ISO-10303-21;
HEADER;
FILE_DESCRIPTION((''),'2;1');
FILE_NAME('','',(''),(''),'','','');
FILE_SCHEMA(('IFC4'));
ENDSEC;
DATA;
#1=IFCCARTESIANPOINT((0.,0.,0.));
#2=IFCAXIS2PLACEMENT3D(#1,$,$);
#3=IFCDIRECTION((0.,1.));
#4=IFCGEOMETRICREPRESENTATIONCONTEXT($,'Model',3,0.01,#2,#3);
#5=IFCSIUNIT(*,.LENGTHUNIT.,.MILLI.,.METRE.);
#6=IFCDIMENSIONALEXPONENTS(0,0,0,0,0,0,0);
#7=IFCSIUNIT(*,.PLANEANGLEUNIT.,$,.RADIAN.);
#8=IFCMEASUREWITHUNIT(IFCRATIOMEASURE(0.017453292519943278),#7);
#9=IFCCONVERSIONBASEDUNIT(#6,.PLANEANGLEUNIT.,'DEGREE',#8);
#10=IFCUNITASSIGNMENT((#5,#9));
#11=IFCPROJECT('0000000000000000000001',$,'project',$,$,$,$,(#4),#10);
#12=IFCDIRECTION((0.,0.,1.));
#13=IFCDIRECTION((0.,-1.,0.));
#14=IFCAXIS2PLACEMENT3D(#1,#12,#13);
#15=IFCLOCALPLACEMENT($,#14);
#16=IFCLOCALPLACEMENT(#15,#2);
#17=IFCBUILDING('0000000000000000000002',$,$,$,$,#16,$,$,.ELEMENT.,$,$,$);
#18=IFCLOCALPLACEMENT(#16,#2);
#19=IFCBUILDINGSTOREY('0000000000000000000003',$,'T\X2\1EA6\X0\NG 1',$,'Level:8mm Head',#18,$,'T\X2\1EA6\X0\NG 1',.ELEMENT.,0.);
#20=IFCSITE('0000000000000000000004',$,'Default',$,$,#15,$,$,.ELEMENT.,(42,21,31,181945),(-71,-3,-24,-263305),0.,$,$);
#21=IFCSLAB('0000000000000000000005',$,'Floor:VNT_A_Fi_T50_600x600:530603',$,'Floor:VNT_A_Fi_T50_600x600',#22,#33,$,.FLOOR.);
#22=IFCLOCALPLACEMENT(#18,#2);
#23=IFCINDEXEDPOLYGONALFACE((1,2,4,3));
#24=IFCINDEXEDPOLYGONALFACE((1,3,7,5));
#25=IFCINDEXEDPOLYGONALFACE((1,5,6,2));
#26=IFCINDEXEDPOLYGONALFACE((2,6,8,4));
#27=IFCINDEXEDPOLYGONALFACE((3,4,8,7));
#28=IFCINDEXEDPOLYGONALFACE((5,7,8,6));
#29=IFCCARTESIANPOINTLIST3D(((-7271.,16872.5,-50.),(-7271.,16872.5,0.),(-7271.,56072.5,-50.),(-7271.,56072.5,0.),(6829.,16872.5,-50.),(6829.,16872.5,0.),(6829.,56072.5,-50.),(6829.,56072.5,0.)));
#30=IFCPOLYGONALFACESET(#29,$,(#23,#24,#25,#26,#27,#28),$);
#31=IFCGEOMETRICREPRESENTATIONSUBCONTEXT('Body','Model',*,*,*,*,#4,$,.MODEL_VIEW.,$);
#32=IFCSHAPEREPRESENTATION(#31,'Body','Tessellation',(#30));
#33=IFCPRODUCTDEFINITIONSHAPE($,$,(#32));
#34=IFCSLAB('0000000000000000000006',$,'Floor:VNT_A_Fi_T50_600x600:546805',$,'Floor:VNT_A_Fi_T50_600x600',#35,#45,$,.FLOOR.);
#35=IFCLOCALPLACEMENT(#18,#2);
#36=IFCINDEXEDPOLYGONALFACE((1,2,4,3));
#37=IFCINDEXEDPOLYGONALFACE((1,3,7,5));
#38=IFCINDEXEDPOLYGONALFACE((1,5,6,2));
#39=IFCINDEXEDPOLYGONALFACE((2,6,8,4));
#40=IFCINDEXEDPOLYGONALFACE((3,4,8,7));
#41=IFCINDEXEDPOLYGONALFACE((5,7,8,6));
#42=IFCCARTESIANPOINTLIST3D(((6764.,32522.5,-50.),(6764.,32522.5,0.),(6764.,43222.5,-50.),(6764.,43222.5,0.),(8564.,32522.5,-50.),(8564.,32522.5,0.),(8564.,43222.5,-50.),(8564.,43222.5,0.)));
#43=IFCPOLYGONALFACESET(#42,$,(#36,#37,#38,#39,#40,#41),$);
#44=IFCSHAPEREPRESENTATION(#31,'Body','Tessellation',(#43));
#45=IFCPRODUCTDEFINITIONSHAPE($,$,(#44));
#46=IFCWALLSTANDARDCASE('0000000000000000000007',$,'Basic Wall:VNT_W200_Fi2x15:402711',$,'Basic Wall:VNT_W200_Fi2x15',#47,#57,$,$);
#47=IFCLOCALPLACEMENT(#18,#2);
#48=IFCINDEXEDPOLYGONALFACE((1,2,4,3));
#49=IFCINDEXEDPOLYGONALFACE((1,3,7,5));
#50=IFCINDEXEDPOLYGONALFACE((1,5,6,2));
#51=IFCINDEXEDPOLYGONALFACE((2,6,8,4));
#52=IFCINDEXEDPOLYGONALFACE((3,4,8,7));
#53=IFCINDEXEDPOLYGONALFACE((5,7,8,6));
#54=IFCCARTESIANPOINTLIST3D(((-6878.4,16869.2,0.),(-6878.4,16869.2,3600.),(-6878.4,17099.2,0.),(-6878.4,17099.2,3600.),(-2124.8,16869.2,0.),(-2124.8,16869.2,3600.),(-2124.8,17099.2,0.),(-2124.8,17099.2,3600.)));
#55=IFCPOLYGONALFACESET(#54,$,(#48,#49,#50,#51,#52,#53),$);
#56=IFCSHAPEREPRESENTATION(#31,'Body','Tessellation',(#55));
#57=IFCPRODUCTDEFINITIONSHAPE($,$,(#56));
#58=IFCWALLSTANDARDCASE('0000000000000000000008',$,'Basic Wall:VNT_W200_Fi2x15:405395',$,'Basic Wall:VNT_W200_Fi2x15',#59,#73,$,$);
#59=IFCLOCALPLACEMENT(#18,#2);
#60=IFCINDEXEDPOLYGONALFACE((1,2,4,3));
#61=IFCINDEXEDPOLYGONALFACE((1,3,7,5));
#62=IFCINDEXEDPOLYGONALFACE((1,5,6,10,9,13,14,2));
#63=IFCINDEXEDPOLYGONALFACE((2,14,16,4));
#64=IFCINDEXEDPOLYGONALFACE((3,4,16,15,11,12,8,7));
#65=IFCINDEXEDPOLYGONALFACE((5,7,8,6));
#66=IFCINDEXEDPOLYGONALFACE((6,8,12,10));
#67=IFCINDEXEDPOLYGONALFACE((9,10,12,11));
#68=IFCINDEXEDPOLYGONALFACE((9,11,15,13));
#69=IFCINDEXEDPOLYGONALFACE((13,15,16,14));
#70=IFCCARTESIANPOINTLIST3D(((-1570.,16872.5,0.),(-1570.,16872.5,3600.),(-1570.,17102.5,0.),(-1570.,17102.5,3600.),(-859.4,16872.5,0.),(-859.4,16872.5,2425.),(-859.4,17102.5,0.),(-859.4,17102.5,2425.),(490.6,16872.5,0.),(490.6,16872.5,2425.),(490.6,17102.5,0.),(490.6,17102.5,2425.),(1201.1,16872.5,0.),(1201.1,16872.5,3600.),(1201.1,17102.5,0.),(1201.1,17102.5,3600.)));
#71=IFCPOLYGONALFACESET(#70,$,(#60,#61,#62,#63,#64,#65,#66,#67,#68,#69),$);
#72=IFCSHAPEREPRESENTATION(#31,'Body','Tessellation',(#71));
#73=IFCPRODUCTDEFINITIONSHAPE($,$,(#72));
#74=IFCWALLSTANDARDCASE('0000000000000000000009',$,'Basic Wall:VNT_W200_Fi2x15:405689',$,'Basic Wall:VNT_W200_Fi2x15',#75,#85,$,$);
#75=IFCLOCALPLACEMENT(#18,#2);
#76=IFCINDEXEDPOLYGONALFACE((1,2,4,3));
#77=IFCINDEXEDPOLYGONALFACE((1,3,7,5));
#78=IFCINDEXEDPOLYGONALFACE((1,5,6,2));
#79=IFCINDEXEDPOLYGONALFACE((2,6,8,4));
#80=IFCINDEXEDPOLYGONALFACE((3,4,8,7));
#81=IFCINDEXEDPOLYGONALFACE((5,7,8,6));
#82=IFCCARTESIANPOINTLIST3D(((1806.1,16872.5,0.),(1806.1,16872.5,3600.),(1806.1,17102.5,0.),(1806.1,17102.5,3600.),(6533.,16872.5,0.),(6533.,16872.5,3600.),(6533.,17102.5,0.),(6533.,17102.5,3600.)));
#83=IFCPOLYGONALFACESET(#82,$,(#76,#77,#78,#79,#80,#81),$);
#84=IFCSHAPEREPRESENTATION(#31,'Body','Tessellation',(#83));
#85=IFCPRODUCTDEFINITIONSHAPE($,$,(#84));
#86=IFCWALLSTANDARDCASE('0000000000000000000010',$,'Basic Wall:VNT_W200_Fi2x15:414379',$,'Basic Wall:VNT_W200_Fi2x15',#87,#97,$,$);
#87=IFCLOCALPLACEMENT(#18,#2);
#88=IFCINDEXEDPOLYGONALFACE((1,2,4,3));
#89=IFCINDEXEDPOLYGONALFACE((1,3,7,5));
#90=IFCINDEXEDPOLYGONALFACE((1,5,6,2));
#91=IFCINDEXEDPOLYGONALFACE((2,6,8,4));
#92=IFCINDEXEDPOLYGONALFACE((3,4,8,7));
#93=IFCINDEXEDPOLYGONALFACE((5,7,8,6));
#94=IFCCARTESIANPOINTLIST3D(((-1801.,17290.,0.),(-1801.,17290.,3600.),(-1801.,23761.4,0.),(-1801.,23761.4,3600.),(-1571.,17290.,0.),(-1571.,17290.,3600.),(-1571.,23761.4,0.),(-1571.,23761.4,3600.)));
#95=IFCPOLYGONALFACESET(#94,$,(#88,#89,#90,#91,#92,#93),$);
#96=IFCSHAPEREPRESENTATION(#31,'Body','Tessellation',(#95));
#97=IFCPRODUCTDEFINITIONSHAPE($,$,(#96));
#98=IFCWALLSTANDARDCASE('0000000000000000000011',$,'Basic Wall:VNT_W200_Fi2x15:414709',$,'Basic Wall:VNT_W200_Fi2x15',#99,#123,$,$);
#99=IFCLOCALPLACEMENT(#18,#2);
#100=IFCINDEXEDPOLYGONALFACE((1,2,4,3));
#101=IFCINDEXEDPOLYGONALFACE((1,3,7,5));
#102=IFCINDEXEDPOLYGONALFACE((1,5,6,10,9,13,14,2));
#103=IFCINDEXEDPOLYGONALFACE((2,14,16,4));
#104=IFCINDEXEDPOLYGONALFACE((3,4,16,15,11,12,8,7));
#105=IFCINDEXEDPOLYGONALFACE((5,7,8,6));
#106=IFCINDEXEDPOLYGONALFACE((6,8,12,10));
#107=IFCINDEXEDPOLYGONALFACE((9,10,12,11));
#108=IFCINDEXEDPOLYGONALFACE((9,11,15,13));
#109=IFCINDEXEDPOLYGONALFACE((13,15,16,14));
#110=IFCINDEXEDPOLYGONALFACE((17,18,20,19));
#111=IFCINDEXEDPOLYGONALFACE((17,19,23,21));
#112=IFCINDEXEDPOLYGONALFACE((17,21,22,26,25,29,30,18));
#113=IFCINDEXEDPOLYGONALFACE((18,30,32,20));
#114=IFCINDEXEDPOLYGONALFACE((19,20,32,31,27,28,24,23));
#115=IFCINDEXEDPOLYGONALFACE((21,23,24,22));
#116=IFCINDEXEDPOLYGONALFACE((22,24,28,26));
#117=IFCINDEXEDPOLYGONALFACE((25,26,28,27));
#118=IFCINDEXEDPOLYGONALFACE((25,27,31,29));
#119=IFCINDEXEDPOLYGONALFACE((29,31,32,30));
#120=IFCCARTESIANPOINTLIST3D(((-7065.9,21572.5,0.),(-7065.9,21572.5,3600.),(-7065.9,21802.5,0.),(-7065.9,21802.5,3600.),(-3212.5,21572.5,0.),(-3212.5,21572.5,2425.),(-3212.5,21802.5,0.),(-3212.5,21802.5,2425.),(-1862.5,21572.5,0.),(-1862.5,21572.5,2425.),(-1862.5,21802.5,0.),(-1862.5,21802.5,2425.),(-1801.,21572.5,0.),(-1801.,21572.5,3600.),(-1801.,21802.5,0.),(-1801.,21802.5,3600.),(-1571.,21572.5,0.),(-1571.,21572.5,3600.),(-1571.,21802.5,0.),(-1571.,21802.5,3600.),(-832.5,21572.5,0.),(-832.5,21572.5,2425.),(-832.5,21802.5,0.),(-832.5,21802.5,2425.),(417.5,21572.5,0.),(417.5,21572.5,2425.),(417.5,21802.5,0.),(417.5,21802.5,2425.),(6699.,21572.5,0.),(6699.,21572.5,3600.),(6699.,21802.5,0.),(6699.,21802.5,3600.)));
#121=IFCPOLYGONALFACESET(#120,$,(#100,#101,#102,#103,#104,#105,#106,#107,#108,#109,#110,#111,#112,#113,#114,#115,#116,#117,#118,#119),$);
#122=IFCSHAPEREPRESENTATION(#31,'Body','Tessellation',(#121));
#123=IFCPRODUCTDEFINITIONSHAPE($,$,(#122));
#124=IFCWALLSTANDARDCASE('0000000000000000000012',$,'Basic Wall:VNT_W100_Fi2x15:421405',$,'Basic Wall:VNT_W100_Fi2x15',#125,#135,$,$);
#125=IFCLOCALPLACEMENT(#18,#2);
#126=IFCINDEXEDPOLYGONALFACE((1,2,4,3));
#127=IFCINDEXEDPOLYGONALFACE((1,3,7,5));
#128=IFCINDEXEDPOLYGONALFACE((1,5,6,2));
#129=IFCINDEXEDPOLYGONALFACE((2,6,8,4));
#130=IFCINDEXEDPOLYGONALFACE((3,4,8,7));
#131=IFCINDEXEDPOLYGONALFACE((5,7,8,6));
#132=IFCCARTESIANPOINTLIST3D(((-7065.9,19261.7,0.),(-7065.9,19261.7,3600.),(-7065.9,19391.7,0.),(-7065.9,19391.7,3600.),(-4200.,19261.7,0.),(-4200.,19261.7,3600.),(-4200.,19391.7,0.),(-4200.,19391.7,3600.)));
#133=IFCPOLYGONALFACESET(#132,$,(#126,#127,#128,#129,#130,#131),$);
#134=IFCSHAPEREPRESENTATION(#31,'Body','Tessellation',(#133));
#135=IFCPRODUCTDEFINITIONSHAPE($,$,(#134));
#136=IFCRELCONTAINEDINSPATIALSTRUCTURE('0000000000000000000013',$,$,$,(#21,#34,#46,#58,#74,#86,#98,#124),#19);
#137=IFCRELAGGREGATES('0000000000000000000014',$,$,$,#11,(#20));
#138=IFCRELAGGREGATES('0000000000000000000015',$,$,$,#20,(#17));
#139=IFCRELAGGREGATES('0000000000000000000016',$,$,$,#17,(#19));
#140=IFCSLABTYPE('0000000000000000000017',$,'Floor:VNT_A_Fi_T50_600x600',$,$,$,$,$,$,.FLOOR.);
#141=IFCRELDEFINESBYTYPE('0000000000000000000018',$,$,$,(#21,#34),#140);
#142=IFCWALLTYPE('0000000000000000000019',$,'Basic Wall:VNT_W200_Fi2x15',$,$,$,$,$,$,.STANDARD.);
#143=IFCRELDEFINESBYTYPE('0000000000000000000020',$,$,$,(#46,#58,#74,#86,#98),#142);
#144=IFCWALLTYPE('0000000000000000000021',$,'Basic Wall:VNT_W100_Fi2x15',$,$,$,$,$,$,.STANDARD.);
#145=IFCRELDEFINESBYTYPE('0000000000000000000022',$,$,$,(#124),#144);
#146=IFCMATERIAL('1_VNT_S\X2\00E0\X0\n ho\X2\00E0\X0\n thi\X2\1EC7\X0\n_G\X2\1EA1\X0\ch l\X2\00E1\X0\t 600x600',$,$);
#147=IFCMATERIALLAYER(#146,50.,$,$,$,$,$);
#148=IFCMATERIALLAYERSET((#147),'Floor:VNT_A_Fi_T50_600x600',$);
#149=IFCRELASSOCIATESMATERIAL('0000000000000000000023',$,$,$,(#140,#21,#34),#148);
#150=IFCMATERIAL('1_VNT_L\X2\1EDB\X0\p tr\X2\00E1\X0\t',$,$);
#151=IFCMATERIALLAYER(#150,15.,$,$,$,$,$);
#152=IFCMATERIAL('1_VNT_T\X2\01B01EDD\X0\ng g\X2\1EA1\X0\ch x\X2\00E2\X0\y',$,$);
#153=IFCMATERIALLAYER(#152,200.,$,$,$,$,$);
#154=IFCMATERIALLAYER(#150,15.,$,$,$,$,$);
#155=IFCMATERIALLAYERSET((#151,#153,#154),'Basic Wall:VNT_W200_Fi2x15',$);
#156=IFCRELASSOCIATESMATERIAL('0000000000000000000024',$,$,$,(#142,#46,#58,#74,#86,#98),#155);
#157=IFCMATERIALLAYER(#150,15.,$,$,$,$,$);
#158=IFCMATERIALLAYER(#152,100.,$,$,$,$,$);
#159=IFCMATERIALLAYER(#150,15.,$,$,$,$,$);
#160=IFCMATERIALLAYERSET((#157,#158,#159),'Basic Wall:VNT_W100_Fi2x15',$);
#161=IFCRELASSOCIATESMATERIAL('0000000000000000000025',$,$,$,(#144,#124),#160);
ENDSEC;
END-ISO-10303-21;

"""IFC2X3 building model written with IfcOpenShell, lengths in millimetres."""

from ifc_helpers import new_model, entity, si_unit, converted_unit, direction, frame, frame_2d, origin, origin_2d_with_axis, place, context, subcontext, project, spatial, rectangle, extrude, material, layer, layer_set, layer_usage, type_object, element, save


model = new_model("IFC2X3")

# Units and contexts
model_context = context("Model", 3, precision=0.01, world=origin(), true_north=direction((0.0, 1.0)))
body_context = subcontext(model_context, "Body", "Model", "MODEL_VIEW")
ifc_project = project(units=[si_unit("LENGTHUNIT", "METRE", prefix="MILLI"), converted_unit("PLANEANGLEUNIT", "DEGREE", entity("IfcRatioMeasure", 0.017453292519943278), si_unit("PLANEANGLEUNIT", "RADIAN"), dimensions=[0, 0, 0, 0, 0, 0, 0])], contexts=[model_context])

# Site, building, storey
site_placement = place(None, frame((0.0, 0.0, 0.0), z_axis=(0.0, 0.0, 1.0), x_axis=(0.0, -1.0, 0.0)))
site = spatial("IfcSite", under=ifc_project, at=site_placement, Name="Default", CompositionType="ELEMENT", RefLatitude=(42, 21, 31, 181945), RefLongitude=(-71, -3, -24, -263305), RefElevation=0.0)
building_placement = place(site_placement, origin())
building = spatial("IfcBuilding", under=site, at=building_placement, CompositionType="ELEMENT")
storey_placement = place(building_placement, origin())
storey = spatial("IfcBuildingStorey", under=building, at=storey_placement, Name="TẦNG 1", ObjectType="Level:8mm Head", LongName="TẦNG 1", CompositionType="ELEMENT", Elevation=0.0)

# Slabs
ifc_material_1 = material(Name="1_VNT_Sàn hoàn thiện_Gạch lát 600x600")
ifc_layer_1 = layer(ifc_material_1, 50.0)
ifc_layer_set_1 = layer_set([ifc_layer_1], Name="Floor:VNT_A_Fi_T50_600x600")
ifc_layer_usage_1 = layer_usage(ifc_layer_set_1, "AXIS3", "POSITIVE", 0.0)
slab_type = type_object("IfcSlabType", Name="Floor:VNT_A_Fi_T50_600x600", PredefinedType="FLOOR", material=ifc_layer_set_1)
slab_1_placement = place(storey_placement, origin())
element("IfcSlab", 1, at=slab_1_placement, inside=storey, type_object=slab_type, material=ifc_layer_usage_1, Name="Floor:VNT_A_Fi_T50_600x600:530603", ObjectType="Floor:VNT_A_Fi_T50_600x600", PredefinedType="FLOOR", context=body_context, shape_type="SweptSolid", body=[
    extrude(rectangle(XDim=39200.0, YDim=14100.0, at=frame_2d((0.0, 0.0), x_axis=(1.0, 0.0))), frame((-221.0, 36472.5, 0.0), z_axis=(0.0, 0.0, -1.0), x_axis=(0.0, 1.0, 0.0)), (0.0, 0.0, 1.0), 50.0),
])
slab_2_placement = place(storey_placement, origin())
element("IfcSlab", 2, at=slab_2_placement, inside=storey, type_object=slab_type, material=ifc_layer_usage_1, Name="Floor:VNT_A_Fi_T50_600x600:546805", ObjectType="Floor:VNT_A_Fi_T50_600x600", PredefinedType="FLOOR", context=body_context, shape_type="SweptSolid", body=[
    extrude(rectangle(XDim=10700.0, YDim=1800.0, at=frame_2d((0.0, 0.0), x_axis=(1.0, 0.0))), frame((7664.0, 37872.5, 0.0), z_axis=(0.0, 0.0, -1.0), x_axis=(0.0, 1.0, 0.0)), (0.0, 0.0, 1.0), 50.0),
])

# Wall
ifc_material_2 = material(Name="1_VNT_Lớp trát")
ifc_layer_2 = layer(ifc_material_2, 15.0)
ifc_material_3 = material(Name="1_VNT_Tường gạch xây")
ifc_layer_3 = layer(ifc_material_3, 200.0)
ifc_layer_4 = layer(ifc_material_2, 15.0)
ifc_layer_set_2 = layer_set([ifc_layer_2, ifc_layer_3, ifc_layer_4], Name="Basic Wall:VNT_W200_Fi2x15")
ifc_layer_usage_2 = layer_usage(ifc_layer_set_2, "AXIS2", "NEGATIVE", 115.0)
wall_type_1 = type_object("IfcWallType", Name="Basic Wall:VNT_W200_Fi2x15", PredefinedType="STANDARD", material=ifc_layer_set_2)
wall_1_placement = place(storey_placement, frame((-6878.4, 16984.2, 0.0)))
element("IfcWallStandardCase", 3, at=wall_1_placement, inside=storey, type_object=wall_type_1, material=ifc_layer_usage_2, Name="Basic Wall:VNT_W200_Fi2x15:402711", ObjectType="Basic Wall:VNT_W200_Fi2x15", context=body_context, shape_type="SweptSolid", body=[
    extrude(rectangle(XDim=4753.6, YDim=230.0, at=frame_2d((2376.8, 0.0), x_axis=(-1.0, 0.0))), origin(), (0.0, 0.0, 1.0), 3600.0),
])

# Wall, opening
wall_2_placement = place(storey_placement, frame((-1570.0, 16987.5, 0.0)))
wall_2 = element("IfcWallStandardCase", 4, at=wall_2_placement, inside=storey, type_object=wall_type_1, material=ifc_layer_usage_2, Name="Basic Wall:VNT_W200_Fi2x15:405395", ObjectType="Basic Wall:VNT_W200_Fi2x15", context=body_context, shape_type="SweptSolid", body=[
    extrude(rectangle(XDim=2771.1, YDim=230.0, at=frame_2d((1385.6, 0.0), x_axis=(-1.0, 0.0))), origin(), (0.0, 0.0, 1.0), 3600.0),
])
opening_1_placement = place(wall_2_placement, frame((2060.6, 115.0, 0.0)))
element("IfcOpeningElement", 5, at=opening_1_placement, cuts=wall_2, ObjectType="Opening", context=body_context, shape_type="SweptSolid", body=[
    extrude(rectangle(XDim=2425.0, YDim=1350.0, at=frame_2d((1212.5, 675.0), x_axis=(1.0, 0.0))), frame((0.0, 0.0, 0.0), z_axis=(0.0, -1.0, 0.0), x_axis=(0.0, 0.0, 1.0)), (0.0, 0.0, 1.0), 230.0),
])

# Walls
wall_3_placement = place(storey_placement, frame((1806.1, 16987.5, 0.0)))
element("IfcWallStandardCase", 6, at=wall_3_placement, inside=storey, type_object=wall_type_1, material=ifc_layer_usage_2, Name="Basic Wall:VNT_W200_Fi2x15:405689", ObjectType="Basic Wall:VNT_W200_Fi2x15", context=body_context, shape_type="SweptSolid", body=[
    extrude(rectangle(XDim=4726.9, YDim=230.0, at=frame_2d((2363.5, 0.0), x_axis=(-1.0, 0.0))), origin(), (0.0, 0.0, 1.0), 3600.0),
])
wall_4_placement = place(storey_placement, frame((-1686.0, 17290.0, 0.0), z_axis=(0.0, 0.0, 1.0), x_axis=(0.0, 1.0, 0.0)))
element("IfcWallStandardCase", 7, at=wall_4_placement, inside=storey, type_object=wall_type_1, material=ifc_layer_usage_2, Name="Basic Wall:VNT_W200_Fi2x15:414379", ObjectType="Basic Wall:VNT_W200_Fi2x15", context=body_context, shape_type="SweptSolid", body=[
    extrude(rectangle(XDim=6471.4, YDim=230.0, at=frame_2d((3235.7, 0.0), x_axis=(-1.0, 0.0))), origin(), (0.0, 0.0, 1.0), 3600.0),
])

# Wall, openings
wall_5_placement = place(storey_placement, frame((6699.0, 21687.5, 0.0), z_axis=(0.0, 0.0, 1.0), x_axis=(-1.0, 0.0, 0.0)))
wall_5 = element("IfcWallStandardCase", 8, at=wall_5_placement, inside=storey, type_object=wall_type_1, material=ifc_layer_usage_2, Name="Basic Wall:VNT_W200_Fi2x15:414709", ObjectType="Basic Wall:VNT_W200_Fi2x15", context=body_context, shape_type="SweptSolid", body=[
    extrude(rectangle(XDim=13764.9, YDim=230.0, at=frame_2d((6882.5, 0.0), x_axis=(-1.0, 0.0))), origin(), (0.0, 0.0, 1.0), 3600.0),
])
opening_2_placement = place(storey_placement, frame((6699.0, 21687.5, 0.0), z_axis=(0.0, 0.0, 1.0), x_axis=(-1.0, 0.0, 0.0)))
element("IfcOpeningElement", 9, at=opening_2_placement, cuts=wall_5, ObjectType="Opening", context=body_context, shape_type="SweptSolid", body=[
    extrude(rectangle(XDim=3600.0, YDim=230.0, at=origin_2d_with_axis()), frame((8500.0, 0.0, 1800.0), z_axis=(-1.0, 0.0, 0.0), x_axis=(0.0, 0.0, 1.0)), (0.0, 0.0, 1.0), 230.0),
])
opening_3_placement = place(wall_5_placement, frame((8561.4, -115.0, 0.0)))
element("IfcOpeningElement", 10, at=opening_3_placement, cuts=wall_5, ObjectType="Opening", context=body_context, shape_type="SweptSolid", body=[
    extrude(rectangle(XDim=2425.0, YDim=1350.0, at=frame_2d((1212.5, 675.0), x_axis=(1.0, 0.0))), frame((0.0, 0.0, 0.0), z_axis=(0.0, 1.0, 0.0), x_axis=(0.0, 0.0, 1.0)), (0.0, 0.0, 1.0), 230.0),
])
opening_4_placement = place(wall_5_placement, frame((6281.4, -115.0, 0.0)))
element("IfcOpeningElement", 11, at=opening_4_placement, cuts=wall_5, ObjectType="Opening", context=body_context, shape_type="SweptSolid", body=[
    extrude(rectangle(XDim=2425.0, YDim=1250.0, at=frame_2d((1212.5, 625.0), x_axis=(1.0, 0.0))), frame((0.0, 0.0, 0.0), z_axis=(0.0, 1.0, 0.0), x_axis=(0.0, 0.0, 1.0)), (0.0, 0.0, 1.0), 230.0),
])

# Wall
ifc_layer_5 = layer(ifc_material_2, 15.0)
ifc_layer_6 = layer(ifc_material_3, 100.0)
ifc_layer_7 = layer(ifc_material_2, 15.0)
ifc_layer_set_3 = layer_set([ifc_layer_5, ifc_layer_6, ifc_layer_7], Name="Basic Wall:VNT_W100_Fi2x15")
ifc_layer_usage_3 = layer_usage(ifc_layer_set_3, "AXIS2", "NEGATIVE", 65.0)
wall_type_2 = type_object("IfcWallType", Name="Basic Wall:VNT_W100_Fi2x15", PredefinedType="STANDARD", material=ifc_layer_set_3)
wall_6_placement = place(storey_placement, frame((-7065.9, 19326.7, 0.0)))
element("IfcWallStandardCase", 12, at=wall_6_placement, inside=storey, type_object=wall_type_2, material=ifc_layer_usage_3, Name="Basic Wall:VNT_W100_Fi2x15:421405", ObjectType="Basic Wall:VNT_W100_Fi2x15", context=body_context, shape_type="SweptSolid", body=[
    extrude(rectangle(XDim=2866.0, YDim=130.0, at=frame_2d((1433.0, 0.0), x_axis=(-1.0, 0.0))), origin(), (0.0, 0.0, 1.0), 3600.0),
])

save(model, "model.ifc")
